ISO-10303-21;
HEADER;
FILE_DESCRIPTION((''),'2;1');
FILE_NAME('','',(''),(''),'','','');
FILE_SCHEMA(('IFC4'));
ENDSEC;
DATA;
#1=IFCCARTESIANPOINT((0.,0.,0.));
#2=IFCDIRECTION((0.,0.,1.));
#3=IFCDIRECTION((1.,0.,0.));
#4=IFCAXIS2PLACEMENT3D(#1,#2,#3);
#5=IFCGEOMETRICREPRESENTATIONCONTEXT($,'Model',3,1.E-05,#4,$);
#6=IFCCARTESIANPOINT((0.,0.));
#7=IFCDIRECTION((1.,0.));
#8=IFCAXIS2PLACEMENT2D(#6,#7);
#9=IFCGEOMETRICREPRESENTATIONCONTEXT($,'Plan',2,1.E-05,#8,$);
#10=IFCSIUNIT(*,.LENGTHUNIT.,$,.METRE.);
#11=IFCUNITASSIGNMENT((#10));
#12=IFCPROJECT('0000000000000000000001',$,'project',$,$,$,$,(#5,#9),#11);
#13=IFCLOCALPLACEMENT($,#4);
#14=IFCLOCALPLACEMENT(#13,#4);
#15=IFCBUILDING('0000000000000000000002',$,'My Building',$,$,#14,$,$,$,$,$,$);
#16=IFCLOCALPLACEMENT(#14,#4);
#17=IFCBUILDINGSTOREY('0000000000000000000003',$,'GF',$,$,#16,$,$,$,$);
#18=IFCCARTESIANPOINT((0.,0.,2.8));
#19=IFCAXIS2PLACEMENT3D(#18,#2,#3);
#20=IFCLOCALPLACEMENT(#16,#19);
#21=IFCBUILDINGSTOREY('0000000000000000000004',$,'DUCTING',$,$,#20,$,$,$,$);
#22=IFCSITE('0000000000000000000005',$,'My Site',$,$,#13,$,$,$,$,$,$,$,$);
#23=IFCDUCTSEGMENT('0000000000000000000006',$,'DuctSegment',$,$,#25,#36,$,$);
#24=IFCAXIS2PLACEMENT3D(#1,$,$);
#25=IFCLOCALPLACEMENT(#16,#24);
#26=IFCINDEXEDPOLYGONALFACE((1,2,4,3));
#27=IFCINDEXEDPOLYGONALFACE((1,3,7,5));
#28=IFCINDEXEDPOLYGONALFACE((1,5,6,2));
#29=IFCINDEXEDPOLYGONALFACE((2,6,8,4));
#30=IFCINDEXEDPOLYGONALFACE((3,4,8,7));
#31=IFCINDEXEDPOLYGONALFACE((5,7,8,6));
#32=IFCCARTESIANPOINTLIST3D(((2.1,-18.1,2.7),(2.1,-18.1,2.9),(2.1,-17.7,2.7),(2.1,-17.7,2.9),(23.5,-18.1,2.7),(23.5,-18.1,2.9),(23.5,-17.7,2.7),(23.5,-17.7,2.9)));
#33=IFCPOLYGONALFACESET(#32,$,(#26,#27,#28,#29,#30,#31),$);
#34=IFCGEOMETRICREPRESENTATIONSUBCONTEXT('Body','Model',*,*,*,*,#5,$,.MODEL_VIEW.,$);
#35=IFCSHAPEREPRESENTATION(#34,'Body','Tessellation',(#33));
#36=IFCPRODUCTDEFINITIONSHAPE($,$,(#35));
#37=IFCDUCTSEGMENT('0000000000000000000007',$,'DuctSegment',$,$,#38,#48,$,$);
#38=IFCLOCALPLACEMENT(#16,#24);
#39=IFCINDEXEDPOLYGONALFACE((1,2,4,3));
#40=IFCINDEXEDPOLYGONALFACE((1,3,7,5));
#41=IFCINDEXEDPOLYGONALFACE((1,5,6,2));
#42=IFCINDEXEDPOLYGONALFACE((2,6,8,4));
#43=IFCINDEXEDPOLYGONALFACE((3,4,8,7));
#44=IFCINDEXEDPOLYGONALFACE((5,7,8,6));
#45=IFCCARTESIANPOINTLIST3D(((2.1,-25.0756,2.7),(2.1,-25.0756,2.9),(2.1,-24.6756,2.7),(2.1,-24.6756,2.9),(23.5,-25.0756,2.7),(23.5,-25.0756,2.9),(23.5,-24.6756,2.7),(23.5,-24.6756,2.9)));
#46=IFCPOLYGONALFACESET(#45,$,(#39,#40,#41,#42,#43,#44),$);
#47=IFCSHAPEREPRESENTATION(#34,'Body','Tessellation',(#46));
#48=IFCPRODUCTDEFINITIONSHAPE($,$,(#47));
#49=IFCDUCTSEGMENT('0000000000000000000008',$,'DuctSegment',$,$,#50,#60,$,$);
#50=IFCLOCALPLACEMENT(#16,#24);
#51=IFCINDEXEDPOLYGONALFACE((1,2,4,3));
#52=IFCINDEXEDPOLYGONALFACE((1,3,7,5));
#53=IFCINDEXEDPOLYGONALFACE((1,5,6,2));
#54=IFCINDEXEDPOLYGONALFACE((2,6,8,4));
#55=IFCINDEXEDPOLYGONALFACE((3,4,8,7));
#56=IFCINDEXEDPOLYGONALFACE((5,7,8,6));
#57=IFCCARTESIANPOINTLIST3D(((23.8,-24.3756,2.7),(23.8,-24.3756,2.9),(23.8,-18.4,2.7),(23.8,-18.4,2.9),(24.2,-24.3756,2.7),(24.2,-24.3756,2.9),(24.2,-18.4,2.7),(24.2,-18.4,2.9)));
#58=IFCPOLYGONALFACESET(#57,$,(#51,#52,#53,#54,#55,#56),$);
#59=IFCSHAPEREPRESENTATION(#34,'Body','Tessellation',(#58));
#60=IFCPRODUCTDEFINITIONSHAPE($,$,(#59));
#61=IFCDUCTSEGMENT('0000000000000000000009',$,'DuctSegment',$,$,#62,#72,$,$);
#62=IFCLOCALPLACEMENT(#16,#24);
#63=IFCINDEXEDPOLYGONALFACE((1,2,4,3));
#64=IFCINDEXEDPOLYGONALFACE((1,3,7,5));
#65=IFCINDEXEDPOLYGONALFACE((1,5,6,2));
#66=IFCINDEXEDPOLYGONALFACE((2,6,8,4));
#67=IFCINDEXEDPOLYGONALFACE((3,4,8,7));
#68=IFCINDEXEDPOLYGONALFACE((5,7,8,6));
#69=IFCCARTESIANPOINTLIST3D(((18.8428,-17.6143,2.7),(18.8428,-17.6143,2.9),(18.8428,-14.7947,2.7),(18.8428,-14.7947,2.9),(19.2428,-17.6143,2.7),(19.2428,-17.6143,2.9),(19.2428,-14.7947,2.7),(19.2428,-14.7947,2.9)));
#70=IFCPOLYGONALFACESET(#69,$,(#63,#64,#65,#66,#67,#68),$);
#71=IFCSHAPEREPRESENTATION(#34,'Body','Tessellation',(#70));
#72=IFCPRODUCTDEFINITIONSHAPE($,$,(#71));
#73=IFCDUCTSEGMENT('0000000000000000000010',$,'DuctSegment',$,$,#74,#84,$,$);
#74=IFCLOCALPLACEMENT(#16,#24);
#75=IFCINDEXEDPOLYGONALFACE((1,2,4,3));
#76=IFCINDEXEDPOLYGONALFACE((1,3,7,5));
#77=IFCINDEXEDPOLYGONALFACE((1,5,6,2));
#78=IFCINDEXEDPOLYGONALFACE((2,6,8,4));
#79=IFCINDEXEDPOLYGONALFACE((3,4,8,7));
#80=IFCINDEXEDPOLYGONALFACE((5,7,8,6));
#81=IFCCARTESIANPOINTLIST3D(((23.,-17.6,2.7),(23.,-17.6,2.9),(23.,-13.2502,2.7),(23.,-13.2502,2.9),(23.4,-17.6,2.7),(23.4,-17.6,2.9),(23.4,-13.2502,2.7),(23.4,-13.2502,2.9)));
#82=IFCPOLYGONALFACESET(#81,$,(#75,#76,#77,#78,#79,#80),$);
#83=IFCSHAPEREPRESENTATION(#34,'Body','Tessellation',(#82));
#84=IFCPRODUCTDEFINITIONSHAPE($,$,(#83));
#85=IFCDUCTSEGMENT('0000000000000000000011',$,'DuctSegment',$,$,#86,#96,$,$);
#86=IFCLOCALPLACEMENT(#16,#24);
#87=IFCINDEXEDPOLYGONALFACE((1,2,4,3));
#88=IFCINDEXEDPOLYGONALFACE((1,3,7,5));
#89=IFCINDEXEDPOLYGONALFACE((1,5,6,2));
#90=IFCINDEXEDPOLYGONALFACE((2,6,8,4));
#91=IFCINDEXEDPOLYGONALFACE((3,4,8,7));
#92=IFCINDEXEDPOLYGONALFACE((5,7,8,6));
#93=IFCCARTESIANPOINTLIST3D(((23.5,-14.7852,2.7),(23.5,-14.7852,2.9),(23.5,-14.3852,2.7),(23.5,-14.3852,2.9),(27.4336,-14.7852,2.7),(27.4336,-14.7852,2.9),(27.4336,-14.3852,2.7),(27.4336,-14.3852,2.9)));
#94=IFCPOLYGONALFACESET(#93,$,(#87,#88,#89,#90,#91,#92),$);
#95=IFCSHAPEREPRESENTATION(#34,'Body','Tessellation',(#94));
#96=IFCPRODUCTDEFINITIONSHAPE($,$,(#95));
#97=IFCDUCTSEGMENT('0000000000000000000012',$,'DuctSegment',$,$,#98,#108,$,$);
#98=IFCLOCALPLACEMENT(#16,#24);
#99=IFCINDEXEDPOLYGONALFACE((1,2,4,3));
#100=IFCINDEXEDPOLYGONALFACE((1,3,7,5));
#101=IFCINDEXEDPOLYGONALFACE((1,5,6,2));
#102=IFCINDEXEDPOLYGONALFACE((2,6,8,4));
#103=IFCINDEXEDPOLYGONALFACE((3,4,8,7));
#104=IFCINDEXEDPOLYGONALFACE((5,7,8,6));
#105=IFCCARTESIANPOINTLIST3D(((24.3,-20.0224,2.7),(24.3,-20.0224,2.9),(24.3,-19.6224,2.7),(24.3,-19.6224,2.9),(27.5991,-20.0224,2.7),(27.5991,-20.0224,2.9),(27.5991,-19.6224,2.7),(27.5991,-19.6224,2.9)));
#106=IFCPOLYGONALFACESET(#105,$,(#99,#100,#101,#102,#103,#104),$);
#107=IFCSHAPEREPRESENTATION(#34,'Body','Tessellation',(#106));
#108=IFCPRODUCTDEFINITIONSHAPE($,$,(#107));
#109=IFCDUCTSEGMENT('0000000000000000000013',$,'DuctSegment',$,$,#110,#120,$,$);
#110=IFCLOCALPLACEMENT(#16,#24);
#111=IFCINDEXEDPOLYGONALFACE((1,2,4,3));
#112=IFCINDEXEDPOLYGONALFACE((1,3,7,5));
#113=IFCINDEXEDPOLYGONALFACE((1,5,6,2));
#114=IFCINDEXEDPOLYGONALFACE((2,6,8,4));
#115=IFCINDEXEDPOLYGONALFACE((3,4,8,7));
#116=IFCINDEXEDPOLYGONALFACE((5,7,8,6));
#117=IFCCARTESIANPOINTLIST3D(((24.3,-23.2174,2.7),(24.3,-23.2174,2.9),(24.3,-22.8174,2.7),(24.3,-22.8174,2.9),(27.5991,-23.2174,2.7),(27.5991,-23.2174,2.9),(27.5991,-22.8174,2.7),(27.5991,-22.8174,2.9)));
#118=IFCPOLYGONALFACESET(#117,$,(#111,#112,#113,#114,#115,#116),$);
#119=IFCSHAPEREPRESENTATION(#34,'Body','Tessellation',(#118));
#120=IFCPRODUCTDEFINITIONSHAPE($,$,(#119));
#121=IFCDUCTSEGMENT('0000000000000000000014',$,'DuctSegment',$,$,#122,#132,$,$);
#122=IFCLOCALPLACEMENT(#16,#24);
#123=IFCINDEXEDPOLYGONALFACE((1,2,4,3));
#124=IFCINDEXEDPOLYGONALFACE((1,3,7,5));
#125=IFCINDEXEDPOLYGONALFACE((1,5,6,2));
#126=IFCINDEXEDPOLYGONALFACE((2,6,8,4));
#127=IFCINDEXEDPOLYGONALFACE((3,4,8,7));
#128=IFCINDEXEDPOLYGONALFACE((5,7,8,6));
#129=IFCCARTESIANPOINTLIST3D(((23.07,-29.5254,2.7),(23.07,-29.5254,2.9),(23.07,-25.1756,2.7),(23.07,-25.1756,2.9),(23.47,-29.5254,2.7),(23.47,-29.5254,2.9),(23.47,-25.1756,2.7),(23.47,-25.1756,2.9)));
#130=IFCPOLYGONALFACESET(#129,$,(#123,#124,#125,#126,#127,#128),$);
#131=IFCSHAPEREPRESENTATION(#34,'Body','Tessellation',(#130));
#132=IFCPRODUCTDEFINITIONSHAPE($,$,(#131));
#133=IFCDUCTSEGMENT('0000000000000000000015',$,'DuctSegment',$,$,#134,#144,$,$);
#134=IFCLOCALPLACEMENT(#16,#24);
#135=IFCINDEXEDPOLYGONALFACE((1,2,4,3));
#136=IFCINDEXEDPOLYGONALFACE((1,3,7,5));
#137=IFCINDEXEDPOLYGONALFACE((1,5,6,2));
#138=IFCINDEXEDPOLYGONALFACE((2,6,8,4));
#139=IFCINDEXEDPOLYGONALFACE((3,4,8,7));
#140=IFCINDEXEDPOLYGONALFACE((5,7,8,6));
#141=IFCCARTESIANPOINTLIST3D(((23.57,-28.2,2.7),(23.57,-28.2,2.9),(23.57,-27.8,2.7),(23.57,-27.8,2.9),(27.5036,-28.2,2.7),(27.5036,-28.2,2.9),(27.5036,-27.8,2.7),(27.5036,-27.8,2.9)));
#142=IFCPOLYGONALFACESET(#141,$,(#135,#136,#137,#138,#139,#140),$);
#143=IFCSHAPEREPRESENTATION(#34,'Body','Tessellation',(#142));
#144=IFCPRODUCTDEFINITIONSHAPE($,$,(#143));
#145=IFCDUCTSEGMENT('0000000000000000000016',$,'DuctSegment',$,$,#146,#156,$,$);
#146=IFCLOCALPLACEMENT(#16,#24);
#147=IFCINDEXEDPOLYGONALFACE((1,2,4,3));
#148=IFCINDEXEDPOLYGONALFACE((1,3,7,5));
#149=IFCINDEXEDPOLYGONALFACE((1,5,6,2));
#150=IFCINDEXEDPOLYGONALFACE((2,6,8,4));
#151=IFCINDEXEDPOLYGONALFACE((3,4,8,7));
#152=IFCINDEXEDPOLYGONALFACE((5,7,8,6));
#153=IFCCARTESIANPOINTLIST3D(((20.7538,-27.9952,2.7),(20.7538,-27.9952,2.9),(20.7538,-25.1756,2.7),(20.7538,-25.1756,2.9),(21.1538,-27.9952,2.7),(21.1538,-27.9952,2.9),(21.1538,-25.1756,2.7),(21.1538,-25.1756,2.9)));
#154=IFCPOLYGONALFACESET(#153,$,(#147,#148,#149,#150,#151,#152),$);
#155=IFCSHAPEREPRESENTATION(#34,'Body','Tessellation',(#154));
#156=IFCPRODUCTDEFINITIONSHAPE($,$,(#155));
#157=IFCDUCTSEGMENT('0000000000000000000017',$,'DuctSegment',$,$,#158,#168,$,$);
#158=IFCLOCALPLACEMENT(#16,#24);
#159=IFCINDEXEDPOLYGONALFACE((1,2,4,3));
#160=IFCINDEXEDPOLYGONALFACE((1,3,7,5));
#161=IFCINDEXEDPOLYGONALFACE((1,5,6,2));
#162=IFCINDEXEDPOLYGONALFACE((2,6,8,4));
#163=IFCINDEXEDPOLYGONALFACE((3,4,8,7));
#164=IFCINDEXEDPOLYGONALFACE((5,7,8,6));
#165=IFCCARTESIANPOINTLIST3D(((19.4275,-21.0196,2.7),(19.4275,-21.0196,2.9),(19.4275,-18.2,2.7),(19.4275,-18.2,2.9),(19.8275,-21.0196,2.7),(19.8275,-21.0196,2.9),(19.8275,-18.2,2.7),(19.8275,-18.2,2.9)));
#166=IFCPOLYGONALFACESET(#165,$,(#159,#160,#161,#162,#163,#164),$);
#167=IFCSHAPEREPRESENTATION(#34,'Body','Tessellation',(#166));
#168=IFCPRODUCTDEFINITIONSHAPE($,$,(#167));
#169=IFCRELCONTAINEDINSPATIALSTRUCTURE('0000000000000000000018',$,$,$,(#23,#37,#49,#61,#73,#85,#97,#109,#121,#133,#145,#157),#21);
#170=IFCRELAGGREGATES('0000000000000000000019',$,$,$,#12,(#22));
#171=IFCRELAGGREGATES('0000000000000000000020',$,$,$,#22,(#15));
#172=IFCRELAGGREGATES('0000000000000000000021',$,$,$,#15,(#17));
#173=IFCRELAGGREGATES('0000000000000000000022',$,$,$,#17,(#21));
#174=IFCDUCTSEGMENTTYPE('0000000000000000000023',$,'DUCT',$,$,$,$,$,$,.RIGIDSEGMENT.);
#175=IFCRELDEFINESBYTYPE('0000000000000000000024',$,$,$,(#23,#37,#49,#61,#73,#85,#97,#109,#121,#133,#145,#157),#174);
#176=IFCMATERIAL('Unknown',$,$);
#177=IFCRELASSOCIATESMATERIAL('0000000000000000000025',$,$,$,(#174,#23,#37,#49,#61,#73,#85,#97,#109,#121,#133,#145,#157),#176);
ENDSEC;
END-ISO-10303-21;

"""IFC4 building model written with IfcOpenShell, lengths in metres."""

from ifc_helpers import new_model, si_unit, frame, origin_with_axes, origin_2d_with_axis, place, context, subcontext, project, spatial, rectangle, extrude, material, material_profile, profile_set, profile_usage, type_object, element, save


model = new_model("IFC4")

# Units and contexts
model_context = context("Model", 3, precision=1e-05, world=origin_with_axes())
plan_context = context("Plan", 2, precision=1e-05, world=origin_2d_with_axis())
body_context = subcontext(model_context, "Body", "Model", "MODEL_VIEW")
ifc_project = project(units=[si_unit("LENGTHUNIT", "METRE")], contexts=[model_context, plan_context])

# Site, building, storeys
site_placement = place(None, origin_with_axes())
site = spatial("IfcSite", under=ifc_project, at=site_placement, Name="My Site")
building_placement = place(site_placement, origin_with_axes())
building = spatial("IfcBuilding", under=site, at=building_placement, Name="My Building")
storey_1_placement = place(building_placement, origin_with_axes())
storey_1 = spatial("IfcBuildingStorey", under=building, at=storey_1_placement, Name="GF")
storey_2_placement = place(storey_1_placement, frame((0.0, 0.0, 2.8), z_axis=(0.0, 0.0, 1.0), x_axis=(1.0, 0.0, 0.0)))
storey_2 = spatial("IfcBuildingStorey", under=storey_1, at=storey_2_placement, Name="DUCTING")

# Duct segments
ifc_material = material(Name="Unknown")
ifc_material_profile_1 = material_profile(ifc_material, rectangle(XDim=0.4, YDim=0.2))
ifc_profile_set_1 = profile_set([ifc_material_profile_1])
ifc_profile_usage_1 = profile_usage(ifc_profile_set_1, cardinal=5)
duct_segment_type = type_object("IfcDuctSegmentType", Name="DUCT", PredefinedType="RIGIDSEGMENT", material=ifc_profile_set_1)
duct_segment_1_placement = place(storey_2_placement, frame((23.5, -17.9, 0.0), z_axis=(-1.0, 0.0, 0.0), x_axis=(0.0, -1.0, 0.0)))
element("IfcDuctSegment", 1, at=duct_segment_1_placement, inside=storey_2, type_object=duct_segment_type, material=ifc_profile_usage_1, Name="DuctSegment", context=body_context, shape_type="SweptSolid", body=[
    extrude(rectangle(XDim=0.4, YDim=0.2), origin_with_axes(), (0.0, 0.0, 1.0), 21.4),
])
ifc_profile_usage_2 = profile_usage(ifc_profile_set_1, cardinal=5)
duct_segment_2_placement = place(storey_2_placement, frame((23.5, -24.8756, 0.0), z_axis=(-1.0, 0.0, 0.0), x_axis=(0.0, -1.0, 0.0)))
element("IfcDuctSegment", 2, at=duct_segment_2_placement, inside=storey_2, type_object=duct_segment_type, material=ifc_profile_usage_2, Name="DuctSegment", context=body_context, shape_type="SweptSolid", body=[
    extrude(rectangle(XDim=0.4, YDim=0.2), origin_with_axes(), (0.0, 0.0, 1.0), 21.4),
])
ifc_profile_usage_3 = profile_usage(ifc_profile_set_1, cardinal=5)
duct_segment_3_placement = place(storey_2_placement, frame((24.0, -18.4, 0.0), z_axis=(0.0, -1.0, 0.0), x_axis=(1.0, 0.0, 0.0)))
element("IfcDuctSegment", 3, at=duct_segment_3_placement, inside=storey_2, type_object=duct_segment_type, material=ifc_profile_usage_3, Name="DuctSegment", context=body_context, shape_type="SweptSolid", body=[
    extrude(rectangle(XDim=0.4, YDim=0.2), origin_with_axes(), (0.0, 0.0, 1.0), 5.9756),
])
ifc_profile_usage_4 = profile_usage(ifc_profile_set_1, cardinal=5)
duct_segment_4_placement = place(storey_2_placement, frame((19.0428, -17.6143, 0.0), z_axis=(0.0, 1.0, 0.0), x_axis=(-1.0, 0.0, 0.0)))
element("IfcDuctSegment", 4, at=duct_segment_4_placement, inside=storey_2, type_object=duct_segment_type, material=ifc_profile_usage_4, Name="DuctSegment", context=body_context, shape_type="SweptSolid", body=[
    extrude(rectangle(XDim=0.4, YDim=0.2), origin_with_axes(), (0.0, 0.0, 1.0), 2.8196),
])
ifc_profile_usage_5 = profile_usage(ifc_profile_set_1, cardinal=5)
duct_segment_5_placement = place(storey_2_placement, frame((23.2, -17.6, 0.0), z_axis=(0.0, 1.0, 0.0), x_axis=(-1.0, 0.0, 0.0)))
element("IfcDuctSegment", 5, at=duct_segment_5_placement, inside=storey_2, type_object=duct_segment_type, material=ifc_profile_usage_5, Name="DuctSegment", context=body_context, shape_type="SweptSolid", body=[
    extrude(rectangle(XDim=0.4, YDim=0.2), origin_with_axes(), (0.0, 0.0, 1.0), 4.3498),
])
ifc_profile_usage_6 = profile_usage(ifc_profile_set_1, cardinal=5)
duct_segment_6_placement = place(storey_2_placement, frame((23.5, -14.5852, 0.0), z_axis=(1.0, 0.0, 0.0), x_axis=(0.0, 1.0, 0.0)))
element("IfcDuctSegment", 6, at=duct_segment_6_placement, inside=storey_2, type_object=duct_segment_type, material=ifc_profile_usage_6, Name="DuctSegment", context=body_context, shape_type="SweptSolid", body=[
    extrude(rectangle(XDim=0.4, YDim=0.2), origin_with_axes(), (0.0, 0.0, 1.0), 3.9336),
])
ifc_profile_usage_7 = profile_usage(ifc_profile_set_1, cardinal=5)
duct_segment_7_placement = place(storey_2_placement, frame((24.3, -19.8224, 0.0), z_axis=(1.0, 0.0, 0.0), x_axis=(0.0, 1.0, 0.0)))
element("IfcDuctSegment", 7, at=duct_segment_7_placement, inside=storey_2, type_object=duct_segment_type, material=ifc_profile_usage_7, Name="DuctSegment", context=body_context, shape_type="SweptSolid", body=[
    extrude(rectangle(XDim=0.4, YDim=0.2), origin_with_axes(), (0.0, 0.0, 1.0), 3.2991),
])
ifc_profile_usage_8 = profile_usage(ifc_profile_set_1, cardinal=5)
duct_segment_8_placement = place(storey_2_placement, frame((24.3, -23.0174, 0.0), z_axis=(1.0, 0.0, 0.0), x_axis=(0.0, 1.0, 0.0)))
element("IfcDuctSegment", 8, at=duct_segment_8_placement, inside=storey_2, type_object=duct_segment_type, material=ifc_profile_usage_8, Name="DuctSegment", context=body_context, shape_type="SweptSolid", body=[
    extrude(rectangle(XDim=0.4, YDim=0.2), origin_with_axes(), (0.0, 0.0, 1.0), 3.2991),
])
ifc_profile_usage_9 = profile_usage(ifc_profile_set_1, cardinal=5)
duct_segment_9_placement = place(storey_2_placement, frame((23.27, -29.5254, 0.0), z_axis=(0.0, 1.0, 0.0), x_axis=(-1.0, 0.0, 0.0)))
element("IfcDuctSegment", 9, at=duct_segment_9_placement, inside=storey_2, type_object=duct_segment_type, material=ifc_profile_usage_9, Name="DuctSegment", context=body_context, shape_type="SweptSolid", body=[
    extrude(rectangle(XDim=0.4, YDim=0.2), origin_with_axes(), (0.0, 0.0, 1.0), 4.3498),
])
ifc_profile_usage_10 = profile_usage(ifc_profile_set_1, cardinal=5)
duct_segment_10_placement = place(storey_2_placement, frame((23.57, -28.0, 0.0), z_axis=(1.0, 0.0, 0.0), x_axis=(0.0, 1.0, 0.0)))
element("IfcDuctSegment", 10, at=duct_segment_10_placement, inside=storey_2, type_object=duct_segment_type, material=ifc_profile_usage_10, Name="DuctSegment", context=body_context, shape_type="SweptSolid", body=[
    extrude(rectangle(XDim=0.4, YDim=0.2), origin_with_axes(), (0.0, 0.0, 1.0), 3.9336),
])
ifc_profile_usage_11 = profile_usage(ifc_profile_set_1, cardinal=5)
duct_segment_11_placement = place(storey_2_placement, frame((20.9538, -27.9952, 0.0), z_axis=(0.0, 1.0, 0.0), x_axis=(-1.0, 0.0, 0.0)))
element("IfcDuctSegment", 11, at=duct_segment_11_placement, inside=storey_2, type_object=duct_segment_type, material=ifc_profile_usage_11, Name="DuctSegment", context=body_context, shape_type="SweptSolid", body=[
    extrude(rectangle(XDim=0.4, YDim=0.2), origin_with_axes(), (0.0, 0.0, 1.0), 2.8196),
])
ifc_profile_usage_12 = profile_usage(ifc_profile_set_1, cardinal=5)
duct_segment_12_placement = place(storey_2_placement, frame((19.6275, -21.0196, 0.0), z_axis=(0.0, 1.0, 0.0), x_axis=(-1.0, 0.0, 0.0)))
element("IfcDuctSegment", 12, at=duct_segment_12_placement, inside=storey_2, type_object=duct_segment_type, material=ifc_profile_usage_12, Name="DuctSegment", context=body_context, shape_type="SweptSolid", body=[
    extrude(rectangle(XDim=0.4, YDim=0.2), origin_with_axes(), (0.0, 0.0, 1.0), 2.8196),
])

save(model, "model.ifc")
